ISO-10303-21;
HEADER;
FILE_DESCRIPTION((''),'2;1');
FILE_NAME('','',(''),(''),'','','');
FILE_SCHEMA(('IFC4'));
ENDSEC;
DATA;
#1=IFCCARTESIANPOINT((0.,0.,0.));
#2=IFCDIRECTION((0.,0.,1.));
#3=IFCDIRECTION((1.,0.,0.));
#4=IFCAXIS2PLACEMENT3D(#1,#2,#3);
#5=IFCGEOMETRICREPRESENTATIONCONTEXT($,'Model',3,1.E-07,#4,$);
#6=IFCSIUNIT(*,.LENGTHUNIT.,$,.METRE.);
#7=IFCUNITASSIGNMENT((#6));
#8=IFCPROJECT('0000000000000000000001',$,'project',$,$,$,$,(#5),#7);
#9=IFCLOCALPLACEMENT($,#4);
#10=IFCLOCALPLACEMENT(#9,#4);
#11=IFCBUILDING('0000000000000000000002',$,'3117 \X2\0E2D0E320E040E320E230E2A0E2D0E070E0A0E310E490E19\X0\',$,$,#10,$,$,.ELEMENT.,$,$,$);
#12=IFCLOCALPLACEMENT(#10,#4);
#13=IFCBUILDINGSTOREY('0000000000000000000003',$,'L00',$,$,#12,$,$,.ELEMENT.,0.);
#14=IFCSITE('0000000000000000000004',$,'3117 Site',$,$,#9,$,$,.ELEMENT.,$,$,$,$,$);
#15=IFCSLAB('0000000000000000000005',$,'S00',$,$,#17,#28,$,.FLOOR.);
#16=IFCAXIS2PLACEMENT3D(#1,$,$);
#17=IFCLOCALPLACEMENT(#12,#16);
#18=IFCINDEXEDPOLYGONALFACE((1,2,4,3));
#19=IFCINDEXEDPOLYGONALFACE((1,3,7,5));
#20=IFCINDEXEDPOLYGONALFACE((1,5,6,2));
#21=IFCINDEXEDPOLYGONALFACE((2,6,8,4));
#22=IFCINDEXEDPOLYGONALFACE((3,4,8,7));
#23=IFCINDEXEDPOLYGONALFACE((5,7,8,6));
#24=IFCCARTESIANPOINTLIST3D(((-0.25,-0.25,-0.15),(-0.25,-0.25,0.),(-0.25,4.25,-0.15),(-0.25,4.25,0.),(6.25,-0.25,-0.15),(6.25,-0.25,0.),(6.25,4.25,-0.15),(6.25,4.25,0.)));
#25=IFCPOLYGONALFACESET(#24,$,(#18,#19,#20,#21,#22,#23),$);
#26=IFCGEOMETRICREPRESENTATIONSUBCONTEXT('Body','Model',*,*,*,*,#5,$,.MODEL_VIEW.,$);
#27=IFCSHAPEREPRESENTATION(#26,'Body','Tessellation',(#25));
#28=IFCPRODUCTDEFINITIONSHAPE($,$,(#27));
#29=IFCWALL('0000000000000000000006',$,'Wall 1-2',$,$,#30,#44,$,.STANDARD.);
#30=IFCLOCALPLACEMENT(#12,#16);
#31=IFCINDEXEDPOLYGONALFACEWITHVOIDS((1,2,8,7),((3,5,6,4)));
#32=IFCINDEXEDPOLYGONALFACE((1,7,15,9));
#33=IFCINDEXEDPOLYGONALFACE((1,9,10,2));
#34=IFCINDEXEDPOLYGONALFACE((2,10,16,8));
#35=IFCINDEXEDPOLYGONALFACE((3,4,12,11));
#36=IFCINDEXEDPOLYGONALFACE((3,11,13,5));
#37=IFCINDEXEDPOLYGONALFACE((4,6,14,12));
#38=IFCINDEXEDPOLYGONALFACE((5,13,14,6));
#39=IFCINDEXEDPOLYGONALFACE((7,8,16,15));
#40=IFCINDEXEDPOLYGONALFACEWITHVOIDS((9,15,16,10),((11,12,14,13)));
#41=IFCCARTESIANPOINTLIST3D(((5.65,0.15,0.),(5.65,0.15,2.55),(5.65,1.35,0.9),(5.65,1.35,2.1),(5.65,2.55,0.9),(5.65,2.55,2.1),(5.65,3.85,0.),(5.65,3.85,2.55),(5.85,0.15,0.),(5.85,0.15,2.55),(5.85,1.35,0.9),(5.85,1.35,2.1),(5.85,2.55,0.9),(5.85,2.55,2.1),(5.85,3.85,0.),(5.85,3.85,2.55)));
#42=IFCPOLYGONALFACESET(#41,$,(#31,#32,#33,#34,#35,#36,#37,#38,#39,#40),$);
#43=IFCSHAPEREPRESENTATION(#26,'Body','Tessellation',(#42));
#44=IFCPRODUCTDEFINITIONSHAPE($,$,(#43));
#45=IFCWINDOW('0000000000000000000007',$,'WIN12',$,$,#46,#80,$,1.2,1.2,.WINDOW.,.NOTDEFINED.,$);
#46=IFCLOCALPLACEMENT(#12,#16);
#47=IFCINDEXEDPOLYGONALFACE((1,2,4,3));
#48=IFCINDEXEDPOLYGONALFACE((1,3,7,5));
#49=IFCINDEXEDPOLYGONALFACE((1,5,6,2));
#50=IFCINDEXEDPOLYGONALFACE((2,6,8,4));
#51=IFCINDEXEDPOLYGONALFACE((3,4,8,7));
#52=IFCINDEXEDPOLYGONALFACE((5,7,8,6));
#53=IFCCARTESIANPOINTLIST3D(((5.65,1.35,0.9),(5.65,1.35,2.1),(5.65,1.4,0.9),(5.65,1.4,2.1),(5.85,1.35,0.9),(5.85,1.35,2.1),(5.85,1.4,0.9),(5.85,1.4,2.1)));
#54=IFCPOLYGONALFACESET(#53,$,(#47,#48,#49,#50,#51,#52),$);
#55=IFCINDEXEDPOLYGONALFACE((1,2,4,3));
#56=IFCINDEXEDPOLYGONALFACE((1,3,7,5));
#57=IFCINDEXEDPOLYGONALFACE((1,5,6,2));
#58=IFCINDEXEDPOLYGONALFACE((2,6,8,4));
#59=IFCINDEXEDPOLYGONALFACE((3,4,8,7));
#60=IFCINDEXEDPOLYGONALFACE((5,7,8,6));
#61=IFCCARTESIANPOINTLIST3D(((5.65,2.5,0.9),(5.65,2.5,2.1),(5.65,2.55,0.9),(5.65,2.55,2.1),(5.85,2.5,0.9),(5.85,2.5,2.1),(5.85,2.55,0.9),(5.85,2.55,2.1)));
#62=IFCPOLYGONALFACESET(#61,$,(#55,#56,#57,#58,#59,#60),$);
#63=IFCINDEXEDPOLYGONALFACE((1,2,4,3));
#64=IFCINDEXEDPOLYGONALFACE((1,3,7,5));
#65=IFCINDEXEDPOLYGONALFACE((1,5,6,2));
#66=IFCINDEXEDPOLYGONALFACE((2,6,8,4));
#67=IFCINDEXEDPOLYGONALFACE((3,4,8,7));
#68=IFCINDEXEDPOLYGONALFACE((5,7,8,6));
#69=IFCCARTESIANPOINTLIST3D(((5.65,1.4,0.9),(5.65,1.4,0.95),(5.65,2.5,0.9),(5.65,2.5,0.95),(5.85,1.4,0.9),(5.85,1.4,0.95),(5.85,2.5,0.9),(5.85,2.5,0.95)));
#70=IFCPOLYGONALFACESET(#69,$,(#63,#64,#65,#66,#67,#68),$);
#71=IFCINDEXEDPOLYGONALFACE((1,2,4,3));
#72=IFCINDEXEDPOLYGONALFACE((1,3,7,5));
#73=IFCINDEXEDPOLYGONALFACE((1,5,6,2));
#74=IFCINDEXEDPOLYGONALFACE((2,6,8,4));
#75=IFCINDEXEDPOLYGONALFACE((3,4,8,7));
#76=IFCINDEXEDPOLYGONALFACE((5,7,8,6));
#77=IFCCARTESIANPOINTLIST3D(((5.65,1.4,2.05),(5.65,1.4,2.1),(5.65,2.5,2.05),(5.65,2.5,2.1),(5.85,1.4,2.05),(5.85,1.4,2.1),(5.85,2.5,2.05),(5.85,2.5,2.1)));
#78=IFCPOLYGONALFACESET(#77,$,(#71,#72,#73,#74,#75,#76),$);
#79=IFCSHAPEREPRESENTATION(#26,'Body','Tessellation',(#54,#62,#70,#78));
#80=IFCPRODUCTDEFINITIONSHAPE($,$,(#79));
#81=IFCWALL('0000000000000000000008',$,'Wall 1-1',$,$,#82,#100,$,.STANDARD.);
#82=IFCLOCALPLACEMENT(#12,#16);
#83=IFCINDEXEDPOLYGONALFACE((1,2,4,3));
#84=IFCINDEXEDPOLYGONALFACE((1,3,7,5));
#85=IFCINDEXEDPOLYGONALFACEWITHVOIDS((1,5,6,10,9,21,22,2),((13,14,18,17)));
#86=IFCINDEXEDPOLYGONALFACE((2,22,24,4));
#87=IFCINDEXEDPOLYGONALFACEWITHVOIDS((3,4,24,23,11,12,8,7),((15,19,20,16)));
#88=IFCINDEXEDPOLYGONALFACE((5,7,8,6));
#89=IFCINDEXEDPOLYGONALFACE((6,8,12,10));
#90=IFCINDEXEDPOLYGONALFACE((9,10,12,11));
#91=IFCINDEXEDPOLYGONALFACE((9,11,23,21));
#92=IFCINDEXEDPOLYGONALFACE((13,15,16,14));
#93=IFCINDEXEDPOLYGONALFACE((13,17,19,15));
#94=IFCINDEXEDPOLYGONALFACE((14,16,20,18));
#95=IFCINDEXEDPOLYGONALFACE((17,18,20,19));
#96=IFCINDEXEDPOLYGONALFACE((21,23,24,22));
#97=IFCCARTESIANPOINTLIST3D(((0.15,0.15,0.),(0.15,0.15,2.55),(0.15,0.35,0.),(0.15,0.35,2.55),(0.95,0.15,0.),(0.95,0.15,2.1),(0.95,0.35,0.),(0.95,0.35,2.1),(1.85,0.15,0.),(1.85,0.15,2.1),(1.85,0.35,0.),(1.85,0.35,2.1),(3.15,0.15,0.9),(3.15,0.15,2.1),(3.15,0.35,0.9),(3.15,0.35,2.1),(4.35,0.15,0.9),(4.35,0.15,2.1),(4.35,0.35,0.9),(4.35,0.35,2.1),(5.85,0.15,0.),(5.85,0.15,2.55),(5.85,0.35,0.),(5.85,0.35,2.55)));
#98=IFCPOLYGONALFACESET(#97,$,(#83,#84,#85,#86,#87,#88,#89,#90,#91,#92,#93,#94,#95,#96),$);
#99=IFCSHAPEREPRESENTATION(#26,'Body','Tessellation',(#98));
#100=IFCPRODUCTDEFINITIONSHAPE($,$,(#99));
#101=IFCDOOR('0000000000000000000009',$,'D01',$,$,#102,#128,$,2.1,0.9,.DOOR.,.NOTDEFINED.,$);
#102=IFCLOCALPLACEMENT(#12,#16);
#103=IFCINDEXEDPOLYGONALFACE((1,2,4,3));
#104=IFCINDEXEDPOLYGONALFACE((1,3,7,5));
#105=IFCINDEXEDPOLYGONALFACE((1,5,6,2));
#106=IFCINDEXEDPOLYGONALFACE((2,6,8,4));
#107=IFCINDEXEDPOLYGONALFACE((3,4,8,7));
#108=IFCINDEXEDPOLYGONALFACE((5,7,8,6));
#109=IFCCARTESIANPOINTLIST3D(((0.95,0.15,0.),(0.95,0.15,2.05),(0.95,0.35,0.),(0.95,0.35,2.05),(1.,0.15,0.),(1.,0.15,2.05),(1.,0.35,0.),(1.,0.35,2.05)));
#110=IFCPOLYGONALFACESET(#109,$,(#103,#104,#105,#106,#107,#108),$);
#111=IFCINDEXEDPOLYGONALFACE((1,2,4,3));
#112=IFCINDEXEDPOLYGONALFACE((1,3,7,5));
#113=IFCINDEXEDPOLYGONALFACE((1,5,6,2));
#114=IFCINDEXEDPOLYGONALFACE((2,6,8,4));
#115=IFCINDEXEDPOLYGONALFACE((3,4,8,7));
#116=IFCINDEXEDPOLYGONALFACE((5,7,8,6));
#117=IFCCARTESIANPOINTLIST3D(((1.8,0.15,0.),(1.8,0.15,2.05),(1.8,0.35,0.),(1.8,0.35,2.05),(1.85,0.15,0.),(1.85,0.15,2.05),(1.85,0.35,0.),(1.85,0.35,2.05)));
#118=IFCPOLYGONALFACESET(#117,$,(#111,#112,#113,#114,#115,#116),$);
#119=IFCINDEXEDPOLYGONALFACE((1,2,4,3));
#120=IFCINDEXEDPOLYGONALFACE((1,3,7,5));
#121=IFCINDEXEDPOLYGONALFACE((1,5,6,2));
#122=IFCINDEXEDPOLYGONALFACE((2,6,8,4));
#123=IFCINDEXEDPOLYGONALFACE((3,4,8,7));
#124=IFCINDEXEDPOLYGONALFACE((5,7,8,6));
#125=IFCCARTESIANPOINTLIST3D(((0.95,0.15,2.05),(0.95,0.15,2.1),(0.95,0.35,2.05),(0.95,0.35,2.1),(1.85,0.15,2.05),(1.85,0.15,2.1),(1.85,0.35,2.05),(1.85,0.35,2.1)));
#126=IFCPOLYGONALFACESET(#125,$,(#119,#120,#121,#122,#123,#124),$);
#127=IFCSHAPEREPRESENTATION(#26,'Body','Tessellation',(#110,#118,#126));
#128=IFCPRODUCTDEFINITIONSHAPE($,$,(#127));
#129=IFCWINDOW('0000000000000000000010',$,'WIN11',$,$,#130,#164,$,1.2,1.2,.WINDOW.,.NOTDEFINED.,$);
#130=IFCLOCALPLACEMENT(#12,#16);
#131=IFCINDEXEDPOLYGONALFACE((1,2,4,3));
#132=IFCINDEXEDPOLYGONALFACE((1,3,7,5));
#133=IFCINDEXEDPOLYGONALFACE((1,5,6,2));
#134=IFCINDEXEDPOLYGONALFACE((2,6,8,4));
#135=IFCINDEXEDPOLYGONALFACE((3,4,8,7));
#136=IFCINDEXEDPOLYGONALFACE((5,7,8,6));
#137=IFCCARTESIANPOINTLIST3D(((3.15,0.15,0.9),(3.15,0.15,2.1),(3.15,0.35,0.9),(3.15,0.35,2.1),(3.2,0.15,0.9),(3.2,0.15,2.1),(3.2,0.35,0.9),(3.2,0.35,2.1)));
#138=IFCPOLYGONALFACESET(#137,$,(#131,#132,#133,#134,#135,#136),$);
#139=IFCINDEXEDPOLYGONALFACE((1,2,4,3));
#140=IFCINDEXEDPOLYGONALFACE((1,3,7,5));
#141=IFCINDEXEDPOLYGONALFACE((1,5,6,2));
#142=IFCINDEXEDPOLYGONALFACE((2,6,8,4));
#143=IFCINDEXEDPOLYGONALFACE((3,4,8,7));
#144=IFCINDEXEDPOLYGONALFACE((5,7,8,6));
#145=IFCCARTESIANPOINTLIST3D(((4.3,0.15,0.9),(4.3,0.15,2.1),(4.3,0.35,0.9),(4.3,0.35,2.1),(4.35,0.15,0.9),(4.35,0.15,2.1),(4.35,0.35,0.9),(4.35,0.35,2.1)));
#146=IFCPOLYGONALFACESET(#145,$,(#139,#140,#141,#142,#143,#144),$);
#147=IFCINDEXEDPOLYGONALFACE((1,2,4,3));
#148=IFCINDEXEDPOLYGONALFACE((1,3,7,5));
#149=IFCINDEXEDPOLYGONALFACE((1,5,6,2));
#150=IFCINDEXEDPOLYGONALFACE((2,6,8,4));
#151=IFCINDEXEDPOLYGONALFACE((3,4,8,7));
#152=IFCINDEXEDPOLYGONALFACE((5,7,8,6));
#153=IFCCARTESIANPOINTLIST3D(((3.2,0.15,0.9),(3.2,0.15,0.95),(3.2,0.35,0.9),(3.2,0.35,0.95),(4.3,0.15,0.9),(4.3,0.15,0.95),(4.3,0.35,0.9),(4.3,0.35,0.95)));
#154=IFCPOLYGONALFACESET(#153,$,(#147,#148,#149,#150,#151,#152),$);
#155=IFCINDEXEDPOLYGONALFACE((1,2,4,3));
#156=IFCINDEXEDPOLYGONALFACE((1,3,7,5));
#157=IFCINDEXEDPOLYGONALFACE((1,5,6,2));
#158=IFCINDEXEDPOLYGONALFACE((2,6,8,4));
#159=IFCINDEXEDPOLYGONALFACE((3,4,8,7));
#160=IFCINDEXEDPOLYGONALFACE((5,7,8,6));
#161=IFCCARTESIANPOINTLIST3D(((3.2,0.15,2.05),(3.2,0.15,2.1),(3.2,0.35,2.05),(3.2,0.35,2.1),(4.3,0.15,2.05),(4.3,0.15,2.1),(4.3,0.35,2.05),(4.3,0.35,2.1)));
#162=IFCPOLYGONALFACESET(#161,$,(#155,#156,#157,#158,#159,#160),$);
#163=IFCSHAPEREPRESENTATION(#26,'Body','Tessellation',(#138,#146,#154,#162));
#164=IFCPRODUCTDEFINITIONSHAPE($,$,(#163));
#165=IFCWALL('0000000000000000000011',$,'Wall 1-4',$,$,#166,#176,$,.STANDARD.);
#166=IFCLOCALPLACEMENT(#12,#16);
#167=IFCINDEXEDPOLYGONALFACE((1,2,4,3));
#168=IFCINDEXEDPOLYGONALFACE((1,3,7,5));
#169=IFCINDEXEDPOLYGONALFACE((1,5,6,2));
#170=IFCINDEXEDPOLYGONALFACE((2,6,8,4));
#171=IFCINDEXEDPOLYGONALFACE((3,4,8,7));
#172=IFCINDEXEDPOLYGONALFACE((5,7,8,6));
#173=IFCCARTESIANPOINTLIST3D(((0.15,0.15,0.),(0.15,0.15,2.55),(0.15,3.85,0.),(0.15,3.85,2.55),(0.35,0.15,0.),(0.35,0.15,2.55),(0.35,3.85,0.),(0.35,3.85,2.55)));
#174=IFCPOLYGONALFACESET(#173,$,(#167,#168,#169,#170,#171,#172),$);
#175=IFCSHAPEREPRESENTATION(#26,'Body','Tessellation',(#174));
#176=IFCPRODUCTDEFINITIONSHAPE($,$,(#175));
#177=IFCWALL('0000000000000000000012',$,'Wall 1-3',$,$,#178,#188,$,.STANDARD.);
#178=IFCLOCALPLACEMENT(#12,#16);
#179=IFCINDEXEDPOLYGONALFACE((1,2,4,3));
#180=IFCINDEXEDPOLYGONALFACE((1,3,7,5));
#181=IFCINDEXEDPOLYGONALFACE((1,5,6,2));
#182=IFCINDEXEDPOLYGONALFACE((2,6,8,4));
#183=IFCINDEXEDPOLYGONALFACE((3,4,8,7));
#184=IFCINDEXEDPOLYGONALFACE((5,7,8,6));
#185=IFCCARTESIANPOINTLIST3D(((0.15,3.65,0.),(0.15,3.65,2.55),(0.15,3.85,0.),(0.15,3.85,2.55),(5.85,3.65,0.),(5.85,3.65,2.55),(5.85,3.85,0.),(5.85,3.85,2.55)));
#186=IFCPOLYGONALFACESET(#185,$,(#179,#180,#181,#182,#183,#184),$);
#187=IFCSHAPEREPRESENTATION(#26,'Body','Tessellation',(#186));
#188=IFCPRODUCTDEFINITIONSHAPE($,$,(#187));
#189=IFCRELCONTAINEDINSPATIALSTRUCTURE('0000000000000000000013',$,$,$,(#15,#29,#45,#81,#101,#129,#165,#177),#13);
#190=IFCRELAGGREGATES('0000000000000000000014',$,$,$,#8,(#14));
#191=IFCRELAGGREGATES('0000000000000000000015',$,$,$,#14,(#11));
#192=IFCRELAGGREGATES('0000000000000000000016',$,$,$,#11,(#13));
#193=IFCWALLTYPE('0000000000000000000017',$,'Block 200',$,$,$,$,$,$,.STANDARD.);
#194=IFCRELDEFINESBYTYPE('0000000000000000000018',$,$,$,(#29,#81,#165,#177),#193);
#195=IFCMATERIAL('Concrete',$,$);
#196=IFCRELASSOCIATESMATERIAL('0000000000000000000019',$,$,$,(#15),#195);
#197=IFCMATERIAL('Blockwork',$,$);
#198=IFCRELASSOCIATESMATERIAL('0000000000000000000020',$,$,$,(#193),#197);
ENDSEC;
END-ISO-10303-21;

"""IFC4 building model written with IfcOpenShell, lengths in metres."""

from ifc_helpers import new_model, si_unit, frame, origin_with_axes, place, context, subcontext, project, spatial, polyline, outline, extrude, material, type_object, element, fill, save


model = new_model("IFC4")

# Units and contexts
model_context = context("Model", 3, precision=1e-07, world=origin_with_axes())
body_context = subcontext(model_context, "Body", "Model", "MODEL_VIEW")
ifc_project = project(units=[si_unit("LENGTHUNIT", "METRE")], contexts=[model_context])

# Site, building, storey
site_placement = place(None, origin_with_axes())
site = spatial("IfcSite", under=ifc_project, at=site_placement, Name="3117 Site", CompositionType="ELEMENT")
building_placement = place(site_placement, origin_with_axes())
building = spatial("IfcBuilding", under=site, at=building_placement, Name="3117 อาคารสองชั้น", CompositionType="ELEMENT")
storey_placement = place(building_placement, origin_with_axes())
storey = spatial("IfcBuildingStorey", under=building, at=storey_placement, Name="L00", CompositionType="ELEMENT", Elevation=0.0)

# Slab
ifc_material_1 = material(Name="Concrete")
slab_placement = place(storey_placement, frame((0.0, 0.0, -0.15), z_axis=(0.0, 0.0, 1.0), x_axis=(1.0, 0.0, 0.0)))
element("IfcSlab", 1, at=slab_placement, inside=storey, material=ifc_material_1, Name="S00", PredefinedType="FLOOR", context=body_context, shape_type="SweptSolid", body=[
    extrude(outline(polyline([(-0.25, -0.25), (6.25, -0.25), (6.25, 4.25), (-0.25, 4.25), (-0.25, -0.25)])), origin_with_axes(), (0.0, 0.0, 1.0), 0.15),
])

# Wall, opening, window
ifc_material_2 = material(Name="Blockwork")
wall_type = type_object("IfcWallType", Name="Block 200", PredefinedType="STANDARD", material=ifc_material_2)
wall_1_placement = place(storey_placement, frame((5.85, 0.15, 0.0), z_axis=(0.0, 0.0, 1.0), x_axis=(0.0, 1.0, 0.0)))
wall_1 = element("IfcWall", 2, at=wall_1_placement, inside=storey, type_object=wall_type, Name="Wall 1-2", PredefinedType="STANDARD", context=body_context, shape_type="SweptSolid", body=[
    extrude(outline(polyline([(0.0, 0.0), (3.7, 0.0), (3.7, 0.2), (0.0, 0.2), (0.0, 0.0)])), origin_with_axes(), (0.0, 0.0, 1.0), 2.55),
])
opening_1_placement = place(wall_1_placement, frame((1.2, 0.0, 0.9), z_axis=(0.0, 0.0, 1.0), x_axis=(1.0, 0.0, 0.0)))
opening_1 = element("IfcOpeningElement", 3, at=opening_1_placement, cuts=wall_1, PredefinedType="OPENING", context=body_context, shape_type="SweptSolid", body=[
    extrude(outline(polyline([(0.0, 0.0), (1.2, 0.0), (1.2, 0.2), (0.0, 0.2), (0.0, 0.0)])), origin_with_axes(), (0.0, 0.0, 1.0), 1.2),
])
window_1_placement = place(opening_1_placement, frame((0.0, 0.0, 0.0), z_axis=(0.0, 0.0, 1.0), x_axis=(1.0, 0.0, 0.0)))
window_1 = element("IfcWindow", 4, at=window_1_placement, inside=storey, Name="WIN12", OverallHeight=1.2, OverallWidth=1.2, PartitioningType="NOTDEFINED", PredefinedType="WINDOW", context=body_context, shape_type="SweptSolid", body=[
    extrude(outline(polyline([(0.0, 0.0), (0.05, 0.0), (0.05, 0.2), (0.0, 0.2), (0.0, 0.0)])), origin_with_axes(), (0.0, 0.0, 1.0), 1.2),
    extrude(outline(polyline([(0.0, 0.0), (0.05, 0.0), (0.05, 0.2), (0.0, 0.2), (0.0, 0.0)])), frame((1.15, 0.0, 0.0), z_axis=(0.0, 0.0, 1.0), x_axis=(1.0, 0.0, 0.0)), (0.0, 0.0, 1.0), 1.2),
    extrude(outline(polyline([(0.0, 0.0), (1.1, 0.0), (1.1, 0.2), (0.0, 0.2), (0.0, 0.0)])), frame((0.05, 0.0, 0.0), z_axis=(0.0, 0.0, 1.0), x_axis=(1.0, 0.0, 0.0)), (0.0, 0.0, 1.0), 0.05),
    extrude(outline(polyline([(0.0, 0.0), (1.1, 0.0), (1.1, 0.2), (0.0, 0.2), (0.0, 0.0)])), frame((0.05, 0.0, 1.15), z_axis=(0.0, 0.0, 1.0), x_axis=(1.0, 0.0, 0.0)), (0.0, 0.0, 1.0), 0.05),
])
fill(opening_1, window_1)

# Wall, openings, door, window
wall_2_placement = place(storey_placement, frame((0.15, 0.15, 0.0), z_axis=(0.0, 0.0, 1.0), x_axis=(1.0, 0.0, 0.0)))
wall_2 = element("IfcWall", 5, at=wall_2_placement, inside=storey, type_object=wall_type, Name="Wall 1-1", PredefinedType="STANDARD", context=body_context, shape_type="SweptSolid", body=[
    extrude(outline(polyline([(0.0, 0.0), (5.7, 0.0), (5.7, 0.2), (0.0, 0.2), (0.0, 0.0)])), origin_with_axes(), (0.0, 0.0, 1.0), 2.55),
])
opening_2_placement = place(wall_2_placement, frame((0.8, 0.0, 0.0), z_axis=(0.0, 0.0, 1.0), x_axis=(1.0, 0.0, 0.0)))
opening_2 = element("IfcOpeningElement", 6, at=opening_2_placement, cuts=wall_2, PredefinedType="OPENING", context=body_context, shape_type="SweptSolid", body=[
    extrude(outline(polyline([(0.0, 0.0), (0.9, 0.0), (0.9, 0.2), (0.0, 0.2), (0.0, 0.0)])), origin_with_axes(), (0.0, 0.0, 1.0), 2.1),
])
opening_3_placement = place(wall_2_placement, frame((3.0, 0.0, 0.9), z_axis=(0.0, 0.0, 1.0), x_axis=(1.0, 0.0, 0.0)))
opening_3 = element("IfcOpeningElement", 7, at=opening_3_placement, cuts=wall_2, PredefinedType="OPENING", context=body_context, shape_type="SweptSolid", body=[
    extrude(outline(polyline([(0.0, 0.0), (1.2, 0.0), (1.2, 0.2), (0.0, 0.2), (0.0, 0.0)])), origin_with_axes(), (0.0, 0.0, 1.0), 1.2),
])
door_placement = place(opening_2_placement, frame((0.0, 0.0, 0.0), z_axis=(0.0, 0.0, 1.0), x_axis=(1.0, 0.0, 0.0)))
door = element("IfcDoor", 8, at=door_placement, inside=storey, Name="D01", OperationType="NOTDEFINED", OverallHeight=2.1, OverallWidth=0.9, PredefinedType="DOOR", context=body_context, shape_type="SweptSolid", body=[
    extrude(outline(polyline([(0.0, 0.0), (0.05, 0.0), (0.05, 0.2), (0.0, 0.2), (0.0, 0.0)])), origin_with_axes(), (0.0, 0.0, 1.0), 2.05),
    extrude(outline(polyline([(0.0, 0.0), (0.05, 0.0), (0.05, 0.2), (0.0, 0.2), (0.0, 0.0)])), frame((0.85, 0.0, 0.0), z_axis=(0.0, 0.0, 1.0), x_axis=(1.0, 0.0, 0.0)), (0.0, 0.0, 1.0), 2.05),
    extrude(outline(polyline([(0.0, 0.0), (0.9, 0.0), (0.9, 0.2), (0.0, 0.2), (0.0, 0.0)])), frame((0.0, 0.0, 2.05), z_axis=(0.0, 0.0, 1.0), x_axis=(1.0, 0.0, 0.0)), (0.0, 0.0, 1.0), 0.05),
])
fill(opening_2, door)
window_2_placement = place(opening_3_placement, frame((0.0, 0.0, 0.0), z_axis=(0.0, 0.0, 1.0), x_axis=(1.0, 0.0, 0.0)))
window_2 = element("IfcWindow", 9, at=window_2_placement, inside=storey, Name="WIN11", OverallHeight=1.2, OverallWidth=1.2, PartitioningType="NOTDEFINED", PredefinedType="WINDOW", context=body_context, shape_type="SweptSolid", body=[
    extrude(outline(polyline([(0.0, 0.0), (0.05, 0.0), (0.05, 0.2), (0.0, 0.2), (0.0, 0.0)])), origin_with_axes(), (0.0, 0.0, 1.0), 1.2),
    extrude(outline(polyline([(0.0, 0.0), (0.05, 0.0), (0.05, 0.2), (0.0, 0.2), (0.0, 0.0)])), frame((1.15, 0.0, 0.0), z_axis=(0.0, 0.0, 1.0), x_axis=(1.0, 0.0, 0.0)), (0.0, 0.0, 1.0), 1.2),
    extrude(outline(polyline([(0.0, 0.0), (1.1, 0.0), (1.1, 0.2), (0.0, 0.2), (0.0, 0.0)])), frame((0.05, 0.0, 0.0), z_axis=(0.0, 0.0, 1.0), x_axis=(1.0, 0.0, 0.0)), (0.0, 0.0, 1.0), 0.05),
    extrude(outline(polyline([(0.0, 0.0), (1.1, 0.0), (1.1, 0.2), (0.0, 0.2), (0.0, 0.0)])), frame((0.05, 0.0, 1.15), z_axis=(0.0, 0.0, 1.0), x_axis=(1.0, 0.0, 0.0)), (0.0, 0.0, 1.0), 0.05),
])
fill(opening_3, window_2)

# Walls
wall_3_placement = place(storey_placement, frame((0.15, 3.85, 0.0), z_axis=(0.0, 0.0, 1.0), x_axis=(0.0, -1.0, 0.0)))
element("IfcWall", 10, at=wall_3_placement, inside=storey, type_object=wall_type, Name="Wall 1-4", PredefinedType="STANDARD", context=body_context, shape_type="SweptSolid", body=[
    extrude(outline(polyline([(0.0, 0.0), (3.7, 0.0), (3.7, 0.2), (0.0, 0.2), (0.0, 0.0)])), origin_with_axes(), (0.0, 0.0, 1.0), 2.55),
])
wall_4_placement = place(storey_placement, frame((5.85, 3.85, 0.0), z_axis=(0.0, 0.0, 1.0), x_axis=(-1.0, 0.0, 0.0)))
element("IfcWall", 11, at=wall_4_placement, inside=storey, type_object=wall_type, Name="Wall 1-3", PredefinedType="STANDARD", context=body_context, shape_type="SweptSolid", body=[
    extrude(outline(polyline([(0.0, 0.0), (5.7, 0.0), (5.7, 0.2), (0.0, 0.2), (0.0, 0.0)])), origin_with_axes(), (0.0, 0.0, 1.0), 2.55),
])

save(model, "model.ifc")
